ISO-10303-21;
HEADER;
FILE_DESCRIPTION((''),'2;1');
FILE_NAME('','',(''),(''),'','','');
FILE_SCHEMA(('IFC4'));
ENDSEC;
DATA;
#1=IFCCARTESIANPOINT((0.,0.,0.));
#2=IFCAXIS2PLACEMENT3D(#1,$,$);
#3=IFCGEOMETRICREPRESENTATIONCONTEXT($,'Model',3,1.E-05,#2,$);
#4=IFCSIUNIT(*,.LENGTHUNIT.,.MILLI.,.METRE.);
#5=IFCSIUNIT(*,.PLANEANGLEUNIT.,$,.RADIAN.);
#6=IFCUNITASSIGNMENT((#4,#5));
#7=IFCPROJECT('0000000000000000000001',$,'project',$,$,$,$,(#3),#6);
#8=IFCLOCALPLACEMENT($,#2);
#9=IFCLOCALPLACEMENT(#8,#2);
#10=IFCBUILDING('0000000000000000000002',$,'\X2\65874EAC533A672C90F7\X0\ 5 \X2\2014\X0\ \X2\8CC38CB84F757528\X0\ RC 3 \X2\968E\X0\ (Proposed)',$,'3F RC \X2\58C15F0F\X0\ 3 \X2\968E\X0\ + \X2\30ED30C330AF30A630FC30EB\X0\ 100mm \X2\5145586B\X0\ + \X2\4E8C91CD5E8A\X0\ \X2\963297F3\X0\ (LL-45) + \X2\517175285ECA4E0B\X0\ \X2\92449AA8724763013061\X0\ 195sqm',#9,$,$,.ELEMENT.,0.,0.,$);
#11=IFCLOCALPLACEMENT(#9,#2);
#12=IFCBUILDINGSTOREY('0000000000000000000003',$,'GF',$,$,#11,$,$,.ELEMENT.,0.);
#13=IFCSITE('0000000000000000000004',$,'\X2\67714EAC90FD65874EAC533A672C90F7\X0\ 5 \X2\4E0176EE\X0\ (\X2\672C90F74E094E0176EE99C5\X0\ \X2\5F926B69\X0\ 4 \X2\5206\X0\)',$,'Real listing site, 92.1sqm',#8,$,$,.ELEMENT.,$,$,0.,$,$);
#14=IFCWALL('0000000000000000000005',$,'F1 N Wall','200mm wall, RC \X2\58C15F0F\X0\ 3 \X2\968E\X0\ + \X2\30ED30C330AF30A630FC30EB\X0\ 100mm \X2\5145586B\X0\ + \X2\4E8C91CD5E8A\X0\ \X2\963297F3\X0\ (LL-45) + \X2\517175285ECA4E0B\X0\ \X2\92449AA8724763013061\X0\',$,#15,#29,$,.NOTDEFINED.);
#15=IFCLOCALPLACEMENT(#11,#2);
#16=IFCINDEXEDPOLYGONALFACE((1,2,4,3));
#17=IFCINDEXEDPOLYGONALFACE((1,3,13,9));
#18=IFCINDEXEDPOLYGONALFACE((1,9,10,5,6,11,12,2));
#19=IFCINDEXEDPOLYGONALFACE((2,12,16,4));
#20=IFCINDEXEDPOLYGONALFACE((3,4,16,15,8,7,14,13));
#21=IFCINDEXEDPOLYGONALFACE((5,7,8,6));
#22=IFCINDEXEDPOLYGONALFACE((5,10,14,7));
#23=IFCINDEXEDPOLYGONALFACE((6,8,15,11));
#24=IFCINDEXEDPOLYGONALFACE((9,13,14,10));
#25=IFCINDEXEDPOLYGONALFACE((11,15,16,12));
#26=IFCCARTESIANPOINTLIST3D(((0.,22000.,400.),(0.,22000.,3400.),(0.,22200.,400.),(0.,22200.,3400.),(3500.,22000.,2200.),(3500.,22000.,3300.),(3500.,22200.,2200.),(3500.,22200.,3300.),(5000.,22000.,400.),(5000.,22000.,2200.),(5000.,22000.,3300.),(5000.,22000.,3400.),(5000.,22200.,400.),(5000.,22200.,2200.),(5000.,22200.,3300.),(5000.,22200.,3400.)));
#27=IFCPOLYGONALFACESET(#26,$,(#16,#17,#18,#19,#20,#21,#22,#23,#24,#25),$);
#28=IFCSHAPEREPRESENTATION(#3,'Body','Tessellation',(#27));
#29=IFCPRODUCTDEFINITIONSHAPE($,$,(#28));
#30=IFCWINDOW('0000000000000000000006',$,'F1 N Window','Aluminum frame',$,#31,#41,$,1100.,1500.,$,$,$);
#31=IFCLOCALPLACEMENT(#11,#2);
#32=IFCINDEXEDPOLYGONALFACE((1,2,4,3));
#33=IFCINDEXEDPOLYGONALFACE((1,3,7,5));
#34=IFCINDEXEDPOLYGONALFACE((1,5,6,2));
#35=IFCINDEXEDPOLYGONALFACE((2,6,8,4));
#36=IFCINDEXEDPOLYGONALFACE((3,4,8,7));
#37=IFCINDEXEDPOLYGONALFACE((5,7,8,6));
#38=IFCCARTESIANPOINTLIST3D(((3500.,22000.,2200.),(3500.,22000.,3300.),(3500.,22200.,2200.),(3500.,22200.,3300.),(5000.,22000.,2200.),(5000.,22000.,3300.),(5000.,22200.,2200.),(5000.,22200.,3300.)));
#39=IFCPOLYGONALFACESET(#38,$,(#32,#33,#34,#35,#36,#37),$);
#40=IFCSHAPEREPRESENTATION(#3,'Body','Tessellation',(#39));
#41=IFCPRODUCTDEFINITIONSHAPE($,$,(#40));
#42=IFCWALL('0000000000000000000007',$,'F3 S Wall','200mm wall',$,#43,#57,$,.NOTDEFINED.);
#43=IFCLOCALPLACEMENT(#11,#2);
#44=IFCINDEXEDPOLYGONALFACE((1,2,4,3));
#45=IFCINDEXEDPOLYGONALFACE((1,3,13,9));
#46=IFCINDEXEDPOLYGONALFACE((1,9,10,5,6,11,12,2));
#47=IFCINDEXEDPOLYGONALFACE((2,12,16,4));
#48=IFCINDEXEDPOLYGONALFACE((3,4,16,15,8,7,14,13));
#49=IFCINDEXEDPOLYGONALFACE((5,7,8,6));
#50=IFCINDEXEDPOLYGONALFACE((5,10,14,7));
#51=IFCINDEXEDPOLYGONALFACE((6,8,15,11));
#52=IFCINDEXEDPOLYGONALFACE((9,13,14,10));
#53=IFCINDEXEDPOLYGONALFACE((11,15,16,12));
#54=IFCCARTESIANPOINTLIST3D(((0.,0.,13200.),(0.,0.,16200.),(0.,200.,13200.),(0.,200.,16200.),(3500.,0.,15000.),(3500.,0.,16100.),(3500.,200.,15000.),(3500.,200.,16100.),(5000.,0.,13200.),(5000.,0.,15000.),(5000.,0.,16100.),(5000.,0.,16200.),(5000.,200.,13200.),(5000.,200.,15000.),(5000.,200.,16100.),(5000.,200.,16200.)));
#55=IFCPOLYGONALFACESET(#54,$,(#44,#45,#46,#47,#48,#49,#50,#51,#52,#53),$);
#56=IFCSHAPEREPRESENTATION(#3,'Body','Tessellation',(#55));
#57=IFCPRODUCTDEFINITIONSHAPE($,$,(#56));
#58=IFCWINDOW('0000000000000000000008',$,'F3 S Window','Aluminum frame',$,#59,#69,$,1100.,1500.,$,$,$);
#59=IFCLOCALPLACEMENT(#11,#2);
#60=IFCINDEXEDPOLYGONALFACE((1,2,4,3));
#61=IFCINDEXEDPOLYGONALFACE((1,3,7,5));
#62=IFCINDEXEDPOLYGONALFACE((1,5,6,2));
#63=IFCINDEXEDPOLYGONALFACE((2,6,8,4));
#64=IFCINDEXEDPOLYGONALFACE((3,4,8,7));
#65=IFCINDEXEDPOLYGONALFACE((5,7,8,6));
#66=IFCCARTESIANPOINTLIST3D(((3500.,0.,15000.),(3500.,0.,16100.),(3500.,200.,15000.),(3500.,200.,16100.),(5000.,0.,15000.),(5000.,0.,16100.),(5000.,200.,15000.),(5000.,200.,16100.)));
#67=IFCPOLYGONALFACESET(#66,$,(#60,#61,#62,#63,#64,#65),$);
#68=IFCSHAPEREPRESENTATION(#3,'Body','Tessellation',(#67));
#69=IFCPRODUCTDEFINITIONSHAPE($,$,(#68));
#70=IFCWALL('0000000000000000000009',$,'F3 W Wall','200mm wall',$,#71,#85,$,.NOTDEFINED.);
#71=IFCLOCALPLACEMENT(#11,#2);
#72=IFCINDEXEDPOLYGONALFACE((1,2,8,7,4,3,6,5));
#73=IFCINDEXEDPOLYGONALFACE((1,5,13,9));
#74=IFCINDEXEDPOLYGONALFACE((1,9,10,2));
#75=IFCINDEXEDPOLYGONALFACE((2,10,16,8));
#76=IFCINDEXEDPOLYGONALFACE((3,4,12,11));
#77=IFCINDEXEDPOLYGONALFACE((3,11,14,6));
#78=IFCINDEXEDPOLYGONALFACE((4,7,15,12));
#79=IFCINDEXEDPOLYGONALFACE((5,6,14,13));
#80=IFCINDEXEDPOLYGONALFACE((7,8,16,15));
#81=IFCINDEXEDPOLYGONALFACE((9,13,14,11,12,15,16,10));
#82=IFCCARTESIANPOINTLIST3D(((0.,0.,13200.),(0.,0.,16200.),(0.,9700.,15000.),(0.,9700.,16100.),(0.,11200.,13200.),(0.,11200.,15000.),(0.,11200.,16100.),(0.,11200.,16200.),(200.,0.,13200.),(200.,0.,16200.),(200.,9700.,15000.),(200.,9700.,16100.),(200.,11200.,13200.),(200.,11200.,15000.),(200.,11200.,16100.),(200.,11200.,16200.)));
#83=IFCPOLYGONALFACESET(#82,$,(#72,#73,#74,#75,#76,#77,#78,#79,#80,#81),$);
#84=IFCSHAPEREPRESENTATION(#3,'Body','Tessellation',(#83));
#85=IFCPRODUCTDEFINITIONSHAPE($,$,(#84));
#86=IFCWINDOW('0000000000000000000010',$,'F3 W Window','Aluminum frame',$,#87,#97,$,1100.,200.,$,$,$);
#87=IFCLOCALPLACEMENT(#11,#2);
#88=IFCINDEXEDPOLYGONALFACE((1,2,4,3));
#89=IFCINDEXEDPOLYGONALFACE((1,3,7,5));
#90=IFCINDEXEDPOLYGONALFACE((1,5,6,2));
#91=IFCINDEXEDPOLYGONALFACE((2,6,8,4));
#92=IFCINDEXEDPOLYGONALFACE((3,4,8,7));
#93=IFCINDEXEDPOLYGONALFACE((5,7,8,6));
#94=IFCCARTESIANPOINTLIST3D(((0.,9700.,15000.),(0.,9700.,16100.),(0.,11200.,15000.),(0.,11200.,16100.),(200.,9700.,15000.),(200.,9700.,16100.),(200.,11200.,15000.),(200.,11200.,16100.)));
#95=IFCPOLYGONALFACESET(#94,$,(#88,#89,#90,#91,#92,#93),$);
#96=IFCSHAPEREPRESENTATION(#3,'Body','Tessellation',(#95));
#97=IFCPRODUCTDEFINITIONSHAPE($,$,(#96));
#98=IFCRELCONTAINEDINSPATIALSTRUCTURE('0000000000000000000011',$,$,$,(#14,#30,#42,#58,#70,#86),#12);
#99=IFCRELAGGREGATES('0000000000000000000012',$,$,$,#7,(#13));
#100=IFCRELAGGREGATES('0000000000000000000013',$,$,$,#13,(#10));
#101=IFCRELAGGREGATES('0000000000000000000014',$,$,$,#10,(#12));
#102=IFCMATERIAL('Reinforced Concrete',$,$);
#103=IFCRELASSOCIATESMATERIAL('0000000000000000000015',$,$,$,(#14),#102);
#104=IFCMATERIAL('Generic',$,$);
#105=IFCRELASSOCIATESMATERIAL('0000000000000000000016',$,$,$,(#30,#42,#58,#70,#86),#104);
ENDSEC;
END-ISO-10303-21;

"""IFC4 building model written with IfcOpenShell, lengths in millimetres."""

from ifc_helpers import new_model, si_unit, frame, frame_2d, origin, place, context, project, spatial, rectangle, extrude, material, element, fill, save


model = new_model("IFC4")

# Units and contexts
model_context = context("Model", 3, precision=1e-05, world=origin())
ifc_project = project(units=[si_unit("LENGTHUNIT", "METRE", prefix="MILLI"), si_unit("PLANEANGLEUNIT", "RADIAN")], contexts=[model_context])

# Site, building, storey
site_placement = place(None, origin())
site = spatial("IfcSite", under=ifc_project, at=site_placement, Name="東京都文京区本郷 5 丁目 (本郷三丁目駅 徒歩 4 分)", ObjectType="Real listing site, 92.1sqm", CompositionType="ELEMENT", RefElevation=0.0)
building_placement = place(site_placement, origin())
building = spatial("IfcBuilding", under=site, at=building_placement, Name="文京区本郷 5 — 賃貸併用 RC 3 階 (Proposed)", ObjectType="3F RC 壁式 3 階 + ロックウール 100mm 充填 + 二重床 防音 (LL-45) + 共用廊下 鉄骨片持ち 195sqm", CompositionType="ELEMENT", ElevationOfRefHeight=0.0, ElevationOfTerrain=0.0)
storey_placement = place(building_placement, origin())
storey = spatial("IfcBuildingStorey", under=building, at=storey_placement, Name="GF", CompositionType="ELEMENT", Elevation=0.0)

# Shared definitions
ifc_material_1 = material(Name="Reinforced Concrete")

# Walls, openings, windows
wall_1_placement = place(storey_placement, frame((0.0, 11000.0, 200.0)))
wall_1 = element("IfcWall", 1, at=wall_1_placement, inside=storey, material=ifc_material_1, Name="F1 N Wall", Description="200mm wall, RC 壁式 3 階 + ロックウール 100mm 充填 + 二重床 防音 (LL-45) + 共用廊下 鉄骨片持ち", PredefinedType="NOTDEFINED", context=model_context, shape_type="SweptSolid", body=[
    extrude(rectangle(XDim=5000.0, YDim=200.0, at=frame_2d((2500.0, 100.0))), frame((0.0, 11000.0, 200.0)), (0.0, 0.0, 1.0), 3000.0),
])
opening_1_placement = place(storey_placement, frame((1750.0, 11000.0, 1100.0)))
opening_1 = element("IfcOpeningElement", 2, at=opening_1_placement, cuts=wall_1, PredefinedType="NOTDEFINED", context=model_context, shape_type="SweptSolid", body=[
    extrude(rectangle(XDim=1500.0, YDim=200.0, at=frame_2d((750.0, 100.0))), frame((1750.0, 11000.0, 1100.0)), (0.0, 0.0, 1.0), 1100.0),
])
ifc_material_2 = material(Name="Generic")
window_1_placement = place(storey_placement, frame((1750.0, 11000.0, 1100.0)))
window_1 = element("IfcWindow", 3, at=window_1_placement, inside=storey, material=ifc_material_2, Name="F1 N Window", Description="Aluminum frame", OverallHeight=1100.0, OverallWidth=1500.0, context=model_context, shape_type="SweptSolid", body=[
    extrude(rectangle(XDim=1500.0, YDim=200.0, at=frame_2d((750.0, 100.0))), frame((1750.0, 11000.0, 1100.0)), (0.0, 0.0, 1.0), 1100.0),
])
fill(opening_1, window_1)
wall_2_placement = place(storey_placement, frame((0.0, 0.0, 6600.0)))
wall_2 = element("IfcWall", 4, at=wall_2_placement, inside=storey, material=ifc_material_2, Name="F3 S Wall", Description="200mm wall", PredefinedType="NOTDEFINED", context=model_context, shape_type="SweptSolid", body=[
    extrude(rectangle(XDim=5000.0, YDim=200.0, at=frame_2d((2500.0, 100.0))), frame((0.0, 0.0, 6600.0)), (0.0, 0.0, 1.0), 3000.0),
])
opening_2_placement = place(storey_placement, frame((1750.0, 0.0, 7500.0)))
opening_2 = element("IfcOpeningElement", 5, at=opening_2_placement, cuts=wall_2, PredefinedType="NOTDEFINED", context=model_context, shape_type="SweptSolid", body=[
    extrude(rectangle(XDim=1500.0, YDim=200.0, at=frame_2d((750.0, 100.0))), frame((1750.0, 0.0, 7500.0)), (0.0, 0.0, 1.0), 1100.0),
])
window_2_placement = place(storey_placement, frame((1750.0, 0.0, 7500.0)))
window_2 = element("IfcWindow", 6, at=window_2_placement, inside=storey, material=ifc_material_2, Name="F3 S Window", Description="Aluminum frame", OverallHeight=1100.0, OverallWidth=1500.0, context=model_context, shape_type="SweptSolid", body=[
    extrude(rectangle(XDim=1500.0, YDim=200.0, at=frame_2d((750.0, 100.0))), frame((1750.0, 0.0, 7500.0)), (0.0, 0.0, 1.0), 1100.0),
])
fill(opening_2, window_2)
wall_3_placement = place(storey_placement, frame((0.0, 0.0, 6600.0)))
wall_3 = element("IfcWall", 7, at=wall_3_placement, inside=storey, material=ifc_material_2, Name="F3 W Wall", Description="200mm wall", PredefinedType="NOTDEFINED", context=model_context, shape_type="SweptSolid", body=[
    extrude(rectangle(XDim=200.0, YDim=11200.0, at=frame_2d((100.0, 5600.0))), frame((0.0, 0.0, 6600.0)), (0.0, 0.0, 1.0), 3000.0),
])
opening_3_placement = place(storey_placement, frame((0.0, 4850.0, 7500.0)))
opening_3 = element("IfcOpeningElement", 8, at=opening_3_placement, cuts=wall_3, PredefinedType="NOTDEFINED", context=model_context, shape_type="SweptSolid", body=[
    extrude(rectangle(XDim=200.0, YDim=1500.0, at=frame_2d((100.0, 750.0))), frame((0.0, 4850.0, 7500.0)), (0.0, 0.0, 1.0), 1100.0),
])
window_3_placement = place(storey_placement, frame((0.0, 4850.0, 7500.0)))
window_3 = element("IfcWindow", 9, at=window_3_placement, inside=storey, material=ifc_material_2, Name="F3 W Window", Description="Aluminum frame", OverallHeight=1100.0, OverallWidth=200.0, context=model_context, shape_type="SweptSolid", body=[
    extrude(rectangle(XDim=200.0, YDim=1500.0, at=frame_2d((100.0, 750.0))), frame((0.0, 4850.0, 7500.0)), (0.0, 0.0, 1.0), 1100.0),
])
fill(opening_3, window_3)

save(model, "model.ifc")
